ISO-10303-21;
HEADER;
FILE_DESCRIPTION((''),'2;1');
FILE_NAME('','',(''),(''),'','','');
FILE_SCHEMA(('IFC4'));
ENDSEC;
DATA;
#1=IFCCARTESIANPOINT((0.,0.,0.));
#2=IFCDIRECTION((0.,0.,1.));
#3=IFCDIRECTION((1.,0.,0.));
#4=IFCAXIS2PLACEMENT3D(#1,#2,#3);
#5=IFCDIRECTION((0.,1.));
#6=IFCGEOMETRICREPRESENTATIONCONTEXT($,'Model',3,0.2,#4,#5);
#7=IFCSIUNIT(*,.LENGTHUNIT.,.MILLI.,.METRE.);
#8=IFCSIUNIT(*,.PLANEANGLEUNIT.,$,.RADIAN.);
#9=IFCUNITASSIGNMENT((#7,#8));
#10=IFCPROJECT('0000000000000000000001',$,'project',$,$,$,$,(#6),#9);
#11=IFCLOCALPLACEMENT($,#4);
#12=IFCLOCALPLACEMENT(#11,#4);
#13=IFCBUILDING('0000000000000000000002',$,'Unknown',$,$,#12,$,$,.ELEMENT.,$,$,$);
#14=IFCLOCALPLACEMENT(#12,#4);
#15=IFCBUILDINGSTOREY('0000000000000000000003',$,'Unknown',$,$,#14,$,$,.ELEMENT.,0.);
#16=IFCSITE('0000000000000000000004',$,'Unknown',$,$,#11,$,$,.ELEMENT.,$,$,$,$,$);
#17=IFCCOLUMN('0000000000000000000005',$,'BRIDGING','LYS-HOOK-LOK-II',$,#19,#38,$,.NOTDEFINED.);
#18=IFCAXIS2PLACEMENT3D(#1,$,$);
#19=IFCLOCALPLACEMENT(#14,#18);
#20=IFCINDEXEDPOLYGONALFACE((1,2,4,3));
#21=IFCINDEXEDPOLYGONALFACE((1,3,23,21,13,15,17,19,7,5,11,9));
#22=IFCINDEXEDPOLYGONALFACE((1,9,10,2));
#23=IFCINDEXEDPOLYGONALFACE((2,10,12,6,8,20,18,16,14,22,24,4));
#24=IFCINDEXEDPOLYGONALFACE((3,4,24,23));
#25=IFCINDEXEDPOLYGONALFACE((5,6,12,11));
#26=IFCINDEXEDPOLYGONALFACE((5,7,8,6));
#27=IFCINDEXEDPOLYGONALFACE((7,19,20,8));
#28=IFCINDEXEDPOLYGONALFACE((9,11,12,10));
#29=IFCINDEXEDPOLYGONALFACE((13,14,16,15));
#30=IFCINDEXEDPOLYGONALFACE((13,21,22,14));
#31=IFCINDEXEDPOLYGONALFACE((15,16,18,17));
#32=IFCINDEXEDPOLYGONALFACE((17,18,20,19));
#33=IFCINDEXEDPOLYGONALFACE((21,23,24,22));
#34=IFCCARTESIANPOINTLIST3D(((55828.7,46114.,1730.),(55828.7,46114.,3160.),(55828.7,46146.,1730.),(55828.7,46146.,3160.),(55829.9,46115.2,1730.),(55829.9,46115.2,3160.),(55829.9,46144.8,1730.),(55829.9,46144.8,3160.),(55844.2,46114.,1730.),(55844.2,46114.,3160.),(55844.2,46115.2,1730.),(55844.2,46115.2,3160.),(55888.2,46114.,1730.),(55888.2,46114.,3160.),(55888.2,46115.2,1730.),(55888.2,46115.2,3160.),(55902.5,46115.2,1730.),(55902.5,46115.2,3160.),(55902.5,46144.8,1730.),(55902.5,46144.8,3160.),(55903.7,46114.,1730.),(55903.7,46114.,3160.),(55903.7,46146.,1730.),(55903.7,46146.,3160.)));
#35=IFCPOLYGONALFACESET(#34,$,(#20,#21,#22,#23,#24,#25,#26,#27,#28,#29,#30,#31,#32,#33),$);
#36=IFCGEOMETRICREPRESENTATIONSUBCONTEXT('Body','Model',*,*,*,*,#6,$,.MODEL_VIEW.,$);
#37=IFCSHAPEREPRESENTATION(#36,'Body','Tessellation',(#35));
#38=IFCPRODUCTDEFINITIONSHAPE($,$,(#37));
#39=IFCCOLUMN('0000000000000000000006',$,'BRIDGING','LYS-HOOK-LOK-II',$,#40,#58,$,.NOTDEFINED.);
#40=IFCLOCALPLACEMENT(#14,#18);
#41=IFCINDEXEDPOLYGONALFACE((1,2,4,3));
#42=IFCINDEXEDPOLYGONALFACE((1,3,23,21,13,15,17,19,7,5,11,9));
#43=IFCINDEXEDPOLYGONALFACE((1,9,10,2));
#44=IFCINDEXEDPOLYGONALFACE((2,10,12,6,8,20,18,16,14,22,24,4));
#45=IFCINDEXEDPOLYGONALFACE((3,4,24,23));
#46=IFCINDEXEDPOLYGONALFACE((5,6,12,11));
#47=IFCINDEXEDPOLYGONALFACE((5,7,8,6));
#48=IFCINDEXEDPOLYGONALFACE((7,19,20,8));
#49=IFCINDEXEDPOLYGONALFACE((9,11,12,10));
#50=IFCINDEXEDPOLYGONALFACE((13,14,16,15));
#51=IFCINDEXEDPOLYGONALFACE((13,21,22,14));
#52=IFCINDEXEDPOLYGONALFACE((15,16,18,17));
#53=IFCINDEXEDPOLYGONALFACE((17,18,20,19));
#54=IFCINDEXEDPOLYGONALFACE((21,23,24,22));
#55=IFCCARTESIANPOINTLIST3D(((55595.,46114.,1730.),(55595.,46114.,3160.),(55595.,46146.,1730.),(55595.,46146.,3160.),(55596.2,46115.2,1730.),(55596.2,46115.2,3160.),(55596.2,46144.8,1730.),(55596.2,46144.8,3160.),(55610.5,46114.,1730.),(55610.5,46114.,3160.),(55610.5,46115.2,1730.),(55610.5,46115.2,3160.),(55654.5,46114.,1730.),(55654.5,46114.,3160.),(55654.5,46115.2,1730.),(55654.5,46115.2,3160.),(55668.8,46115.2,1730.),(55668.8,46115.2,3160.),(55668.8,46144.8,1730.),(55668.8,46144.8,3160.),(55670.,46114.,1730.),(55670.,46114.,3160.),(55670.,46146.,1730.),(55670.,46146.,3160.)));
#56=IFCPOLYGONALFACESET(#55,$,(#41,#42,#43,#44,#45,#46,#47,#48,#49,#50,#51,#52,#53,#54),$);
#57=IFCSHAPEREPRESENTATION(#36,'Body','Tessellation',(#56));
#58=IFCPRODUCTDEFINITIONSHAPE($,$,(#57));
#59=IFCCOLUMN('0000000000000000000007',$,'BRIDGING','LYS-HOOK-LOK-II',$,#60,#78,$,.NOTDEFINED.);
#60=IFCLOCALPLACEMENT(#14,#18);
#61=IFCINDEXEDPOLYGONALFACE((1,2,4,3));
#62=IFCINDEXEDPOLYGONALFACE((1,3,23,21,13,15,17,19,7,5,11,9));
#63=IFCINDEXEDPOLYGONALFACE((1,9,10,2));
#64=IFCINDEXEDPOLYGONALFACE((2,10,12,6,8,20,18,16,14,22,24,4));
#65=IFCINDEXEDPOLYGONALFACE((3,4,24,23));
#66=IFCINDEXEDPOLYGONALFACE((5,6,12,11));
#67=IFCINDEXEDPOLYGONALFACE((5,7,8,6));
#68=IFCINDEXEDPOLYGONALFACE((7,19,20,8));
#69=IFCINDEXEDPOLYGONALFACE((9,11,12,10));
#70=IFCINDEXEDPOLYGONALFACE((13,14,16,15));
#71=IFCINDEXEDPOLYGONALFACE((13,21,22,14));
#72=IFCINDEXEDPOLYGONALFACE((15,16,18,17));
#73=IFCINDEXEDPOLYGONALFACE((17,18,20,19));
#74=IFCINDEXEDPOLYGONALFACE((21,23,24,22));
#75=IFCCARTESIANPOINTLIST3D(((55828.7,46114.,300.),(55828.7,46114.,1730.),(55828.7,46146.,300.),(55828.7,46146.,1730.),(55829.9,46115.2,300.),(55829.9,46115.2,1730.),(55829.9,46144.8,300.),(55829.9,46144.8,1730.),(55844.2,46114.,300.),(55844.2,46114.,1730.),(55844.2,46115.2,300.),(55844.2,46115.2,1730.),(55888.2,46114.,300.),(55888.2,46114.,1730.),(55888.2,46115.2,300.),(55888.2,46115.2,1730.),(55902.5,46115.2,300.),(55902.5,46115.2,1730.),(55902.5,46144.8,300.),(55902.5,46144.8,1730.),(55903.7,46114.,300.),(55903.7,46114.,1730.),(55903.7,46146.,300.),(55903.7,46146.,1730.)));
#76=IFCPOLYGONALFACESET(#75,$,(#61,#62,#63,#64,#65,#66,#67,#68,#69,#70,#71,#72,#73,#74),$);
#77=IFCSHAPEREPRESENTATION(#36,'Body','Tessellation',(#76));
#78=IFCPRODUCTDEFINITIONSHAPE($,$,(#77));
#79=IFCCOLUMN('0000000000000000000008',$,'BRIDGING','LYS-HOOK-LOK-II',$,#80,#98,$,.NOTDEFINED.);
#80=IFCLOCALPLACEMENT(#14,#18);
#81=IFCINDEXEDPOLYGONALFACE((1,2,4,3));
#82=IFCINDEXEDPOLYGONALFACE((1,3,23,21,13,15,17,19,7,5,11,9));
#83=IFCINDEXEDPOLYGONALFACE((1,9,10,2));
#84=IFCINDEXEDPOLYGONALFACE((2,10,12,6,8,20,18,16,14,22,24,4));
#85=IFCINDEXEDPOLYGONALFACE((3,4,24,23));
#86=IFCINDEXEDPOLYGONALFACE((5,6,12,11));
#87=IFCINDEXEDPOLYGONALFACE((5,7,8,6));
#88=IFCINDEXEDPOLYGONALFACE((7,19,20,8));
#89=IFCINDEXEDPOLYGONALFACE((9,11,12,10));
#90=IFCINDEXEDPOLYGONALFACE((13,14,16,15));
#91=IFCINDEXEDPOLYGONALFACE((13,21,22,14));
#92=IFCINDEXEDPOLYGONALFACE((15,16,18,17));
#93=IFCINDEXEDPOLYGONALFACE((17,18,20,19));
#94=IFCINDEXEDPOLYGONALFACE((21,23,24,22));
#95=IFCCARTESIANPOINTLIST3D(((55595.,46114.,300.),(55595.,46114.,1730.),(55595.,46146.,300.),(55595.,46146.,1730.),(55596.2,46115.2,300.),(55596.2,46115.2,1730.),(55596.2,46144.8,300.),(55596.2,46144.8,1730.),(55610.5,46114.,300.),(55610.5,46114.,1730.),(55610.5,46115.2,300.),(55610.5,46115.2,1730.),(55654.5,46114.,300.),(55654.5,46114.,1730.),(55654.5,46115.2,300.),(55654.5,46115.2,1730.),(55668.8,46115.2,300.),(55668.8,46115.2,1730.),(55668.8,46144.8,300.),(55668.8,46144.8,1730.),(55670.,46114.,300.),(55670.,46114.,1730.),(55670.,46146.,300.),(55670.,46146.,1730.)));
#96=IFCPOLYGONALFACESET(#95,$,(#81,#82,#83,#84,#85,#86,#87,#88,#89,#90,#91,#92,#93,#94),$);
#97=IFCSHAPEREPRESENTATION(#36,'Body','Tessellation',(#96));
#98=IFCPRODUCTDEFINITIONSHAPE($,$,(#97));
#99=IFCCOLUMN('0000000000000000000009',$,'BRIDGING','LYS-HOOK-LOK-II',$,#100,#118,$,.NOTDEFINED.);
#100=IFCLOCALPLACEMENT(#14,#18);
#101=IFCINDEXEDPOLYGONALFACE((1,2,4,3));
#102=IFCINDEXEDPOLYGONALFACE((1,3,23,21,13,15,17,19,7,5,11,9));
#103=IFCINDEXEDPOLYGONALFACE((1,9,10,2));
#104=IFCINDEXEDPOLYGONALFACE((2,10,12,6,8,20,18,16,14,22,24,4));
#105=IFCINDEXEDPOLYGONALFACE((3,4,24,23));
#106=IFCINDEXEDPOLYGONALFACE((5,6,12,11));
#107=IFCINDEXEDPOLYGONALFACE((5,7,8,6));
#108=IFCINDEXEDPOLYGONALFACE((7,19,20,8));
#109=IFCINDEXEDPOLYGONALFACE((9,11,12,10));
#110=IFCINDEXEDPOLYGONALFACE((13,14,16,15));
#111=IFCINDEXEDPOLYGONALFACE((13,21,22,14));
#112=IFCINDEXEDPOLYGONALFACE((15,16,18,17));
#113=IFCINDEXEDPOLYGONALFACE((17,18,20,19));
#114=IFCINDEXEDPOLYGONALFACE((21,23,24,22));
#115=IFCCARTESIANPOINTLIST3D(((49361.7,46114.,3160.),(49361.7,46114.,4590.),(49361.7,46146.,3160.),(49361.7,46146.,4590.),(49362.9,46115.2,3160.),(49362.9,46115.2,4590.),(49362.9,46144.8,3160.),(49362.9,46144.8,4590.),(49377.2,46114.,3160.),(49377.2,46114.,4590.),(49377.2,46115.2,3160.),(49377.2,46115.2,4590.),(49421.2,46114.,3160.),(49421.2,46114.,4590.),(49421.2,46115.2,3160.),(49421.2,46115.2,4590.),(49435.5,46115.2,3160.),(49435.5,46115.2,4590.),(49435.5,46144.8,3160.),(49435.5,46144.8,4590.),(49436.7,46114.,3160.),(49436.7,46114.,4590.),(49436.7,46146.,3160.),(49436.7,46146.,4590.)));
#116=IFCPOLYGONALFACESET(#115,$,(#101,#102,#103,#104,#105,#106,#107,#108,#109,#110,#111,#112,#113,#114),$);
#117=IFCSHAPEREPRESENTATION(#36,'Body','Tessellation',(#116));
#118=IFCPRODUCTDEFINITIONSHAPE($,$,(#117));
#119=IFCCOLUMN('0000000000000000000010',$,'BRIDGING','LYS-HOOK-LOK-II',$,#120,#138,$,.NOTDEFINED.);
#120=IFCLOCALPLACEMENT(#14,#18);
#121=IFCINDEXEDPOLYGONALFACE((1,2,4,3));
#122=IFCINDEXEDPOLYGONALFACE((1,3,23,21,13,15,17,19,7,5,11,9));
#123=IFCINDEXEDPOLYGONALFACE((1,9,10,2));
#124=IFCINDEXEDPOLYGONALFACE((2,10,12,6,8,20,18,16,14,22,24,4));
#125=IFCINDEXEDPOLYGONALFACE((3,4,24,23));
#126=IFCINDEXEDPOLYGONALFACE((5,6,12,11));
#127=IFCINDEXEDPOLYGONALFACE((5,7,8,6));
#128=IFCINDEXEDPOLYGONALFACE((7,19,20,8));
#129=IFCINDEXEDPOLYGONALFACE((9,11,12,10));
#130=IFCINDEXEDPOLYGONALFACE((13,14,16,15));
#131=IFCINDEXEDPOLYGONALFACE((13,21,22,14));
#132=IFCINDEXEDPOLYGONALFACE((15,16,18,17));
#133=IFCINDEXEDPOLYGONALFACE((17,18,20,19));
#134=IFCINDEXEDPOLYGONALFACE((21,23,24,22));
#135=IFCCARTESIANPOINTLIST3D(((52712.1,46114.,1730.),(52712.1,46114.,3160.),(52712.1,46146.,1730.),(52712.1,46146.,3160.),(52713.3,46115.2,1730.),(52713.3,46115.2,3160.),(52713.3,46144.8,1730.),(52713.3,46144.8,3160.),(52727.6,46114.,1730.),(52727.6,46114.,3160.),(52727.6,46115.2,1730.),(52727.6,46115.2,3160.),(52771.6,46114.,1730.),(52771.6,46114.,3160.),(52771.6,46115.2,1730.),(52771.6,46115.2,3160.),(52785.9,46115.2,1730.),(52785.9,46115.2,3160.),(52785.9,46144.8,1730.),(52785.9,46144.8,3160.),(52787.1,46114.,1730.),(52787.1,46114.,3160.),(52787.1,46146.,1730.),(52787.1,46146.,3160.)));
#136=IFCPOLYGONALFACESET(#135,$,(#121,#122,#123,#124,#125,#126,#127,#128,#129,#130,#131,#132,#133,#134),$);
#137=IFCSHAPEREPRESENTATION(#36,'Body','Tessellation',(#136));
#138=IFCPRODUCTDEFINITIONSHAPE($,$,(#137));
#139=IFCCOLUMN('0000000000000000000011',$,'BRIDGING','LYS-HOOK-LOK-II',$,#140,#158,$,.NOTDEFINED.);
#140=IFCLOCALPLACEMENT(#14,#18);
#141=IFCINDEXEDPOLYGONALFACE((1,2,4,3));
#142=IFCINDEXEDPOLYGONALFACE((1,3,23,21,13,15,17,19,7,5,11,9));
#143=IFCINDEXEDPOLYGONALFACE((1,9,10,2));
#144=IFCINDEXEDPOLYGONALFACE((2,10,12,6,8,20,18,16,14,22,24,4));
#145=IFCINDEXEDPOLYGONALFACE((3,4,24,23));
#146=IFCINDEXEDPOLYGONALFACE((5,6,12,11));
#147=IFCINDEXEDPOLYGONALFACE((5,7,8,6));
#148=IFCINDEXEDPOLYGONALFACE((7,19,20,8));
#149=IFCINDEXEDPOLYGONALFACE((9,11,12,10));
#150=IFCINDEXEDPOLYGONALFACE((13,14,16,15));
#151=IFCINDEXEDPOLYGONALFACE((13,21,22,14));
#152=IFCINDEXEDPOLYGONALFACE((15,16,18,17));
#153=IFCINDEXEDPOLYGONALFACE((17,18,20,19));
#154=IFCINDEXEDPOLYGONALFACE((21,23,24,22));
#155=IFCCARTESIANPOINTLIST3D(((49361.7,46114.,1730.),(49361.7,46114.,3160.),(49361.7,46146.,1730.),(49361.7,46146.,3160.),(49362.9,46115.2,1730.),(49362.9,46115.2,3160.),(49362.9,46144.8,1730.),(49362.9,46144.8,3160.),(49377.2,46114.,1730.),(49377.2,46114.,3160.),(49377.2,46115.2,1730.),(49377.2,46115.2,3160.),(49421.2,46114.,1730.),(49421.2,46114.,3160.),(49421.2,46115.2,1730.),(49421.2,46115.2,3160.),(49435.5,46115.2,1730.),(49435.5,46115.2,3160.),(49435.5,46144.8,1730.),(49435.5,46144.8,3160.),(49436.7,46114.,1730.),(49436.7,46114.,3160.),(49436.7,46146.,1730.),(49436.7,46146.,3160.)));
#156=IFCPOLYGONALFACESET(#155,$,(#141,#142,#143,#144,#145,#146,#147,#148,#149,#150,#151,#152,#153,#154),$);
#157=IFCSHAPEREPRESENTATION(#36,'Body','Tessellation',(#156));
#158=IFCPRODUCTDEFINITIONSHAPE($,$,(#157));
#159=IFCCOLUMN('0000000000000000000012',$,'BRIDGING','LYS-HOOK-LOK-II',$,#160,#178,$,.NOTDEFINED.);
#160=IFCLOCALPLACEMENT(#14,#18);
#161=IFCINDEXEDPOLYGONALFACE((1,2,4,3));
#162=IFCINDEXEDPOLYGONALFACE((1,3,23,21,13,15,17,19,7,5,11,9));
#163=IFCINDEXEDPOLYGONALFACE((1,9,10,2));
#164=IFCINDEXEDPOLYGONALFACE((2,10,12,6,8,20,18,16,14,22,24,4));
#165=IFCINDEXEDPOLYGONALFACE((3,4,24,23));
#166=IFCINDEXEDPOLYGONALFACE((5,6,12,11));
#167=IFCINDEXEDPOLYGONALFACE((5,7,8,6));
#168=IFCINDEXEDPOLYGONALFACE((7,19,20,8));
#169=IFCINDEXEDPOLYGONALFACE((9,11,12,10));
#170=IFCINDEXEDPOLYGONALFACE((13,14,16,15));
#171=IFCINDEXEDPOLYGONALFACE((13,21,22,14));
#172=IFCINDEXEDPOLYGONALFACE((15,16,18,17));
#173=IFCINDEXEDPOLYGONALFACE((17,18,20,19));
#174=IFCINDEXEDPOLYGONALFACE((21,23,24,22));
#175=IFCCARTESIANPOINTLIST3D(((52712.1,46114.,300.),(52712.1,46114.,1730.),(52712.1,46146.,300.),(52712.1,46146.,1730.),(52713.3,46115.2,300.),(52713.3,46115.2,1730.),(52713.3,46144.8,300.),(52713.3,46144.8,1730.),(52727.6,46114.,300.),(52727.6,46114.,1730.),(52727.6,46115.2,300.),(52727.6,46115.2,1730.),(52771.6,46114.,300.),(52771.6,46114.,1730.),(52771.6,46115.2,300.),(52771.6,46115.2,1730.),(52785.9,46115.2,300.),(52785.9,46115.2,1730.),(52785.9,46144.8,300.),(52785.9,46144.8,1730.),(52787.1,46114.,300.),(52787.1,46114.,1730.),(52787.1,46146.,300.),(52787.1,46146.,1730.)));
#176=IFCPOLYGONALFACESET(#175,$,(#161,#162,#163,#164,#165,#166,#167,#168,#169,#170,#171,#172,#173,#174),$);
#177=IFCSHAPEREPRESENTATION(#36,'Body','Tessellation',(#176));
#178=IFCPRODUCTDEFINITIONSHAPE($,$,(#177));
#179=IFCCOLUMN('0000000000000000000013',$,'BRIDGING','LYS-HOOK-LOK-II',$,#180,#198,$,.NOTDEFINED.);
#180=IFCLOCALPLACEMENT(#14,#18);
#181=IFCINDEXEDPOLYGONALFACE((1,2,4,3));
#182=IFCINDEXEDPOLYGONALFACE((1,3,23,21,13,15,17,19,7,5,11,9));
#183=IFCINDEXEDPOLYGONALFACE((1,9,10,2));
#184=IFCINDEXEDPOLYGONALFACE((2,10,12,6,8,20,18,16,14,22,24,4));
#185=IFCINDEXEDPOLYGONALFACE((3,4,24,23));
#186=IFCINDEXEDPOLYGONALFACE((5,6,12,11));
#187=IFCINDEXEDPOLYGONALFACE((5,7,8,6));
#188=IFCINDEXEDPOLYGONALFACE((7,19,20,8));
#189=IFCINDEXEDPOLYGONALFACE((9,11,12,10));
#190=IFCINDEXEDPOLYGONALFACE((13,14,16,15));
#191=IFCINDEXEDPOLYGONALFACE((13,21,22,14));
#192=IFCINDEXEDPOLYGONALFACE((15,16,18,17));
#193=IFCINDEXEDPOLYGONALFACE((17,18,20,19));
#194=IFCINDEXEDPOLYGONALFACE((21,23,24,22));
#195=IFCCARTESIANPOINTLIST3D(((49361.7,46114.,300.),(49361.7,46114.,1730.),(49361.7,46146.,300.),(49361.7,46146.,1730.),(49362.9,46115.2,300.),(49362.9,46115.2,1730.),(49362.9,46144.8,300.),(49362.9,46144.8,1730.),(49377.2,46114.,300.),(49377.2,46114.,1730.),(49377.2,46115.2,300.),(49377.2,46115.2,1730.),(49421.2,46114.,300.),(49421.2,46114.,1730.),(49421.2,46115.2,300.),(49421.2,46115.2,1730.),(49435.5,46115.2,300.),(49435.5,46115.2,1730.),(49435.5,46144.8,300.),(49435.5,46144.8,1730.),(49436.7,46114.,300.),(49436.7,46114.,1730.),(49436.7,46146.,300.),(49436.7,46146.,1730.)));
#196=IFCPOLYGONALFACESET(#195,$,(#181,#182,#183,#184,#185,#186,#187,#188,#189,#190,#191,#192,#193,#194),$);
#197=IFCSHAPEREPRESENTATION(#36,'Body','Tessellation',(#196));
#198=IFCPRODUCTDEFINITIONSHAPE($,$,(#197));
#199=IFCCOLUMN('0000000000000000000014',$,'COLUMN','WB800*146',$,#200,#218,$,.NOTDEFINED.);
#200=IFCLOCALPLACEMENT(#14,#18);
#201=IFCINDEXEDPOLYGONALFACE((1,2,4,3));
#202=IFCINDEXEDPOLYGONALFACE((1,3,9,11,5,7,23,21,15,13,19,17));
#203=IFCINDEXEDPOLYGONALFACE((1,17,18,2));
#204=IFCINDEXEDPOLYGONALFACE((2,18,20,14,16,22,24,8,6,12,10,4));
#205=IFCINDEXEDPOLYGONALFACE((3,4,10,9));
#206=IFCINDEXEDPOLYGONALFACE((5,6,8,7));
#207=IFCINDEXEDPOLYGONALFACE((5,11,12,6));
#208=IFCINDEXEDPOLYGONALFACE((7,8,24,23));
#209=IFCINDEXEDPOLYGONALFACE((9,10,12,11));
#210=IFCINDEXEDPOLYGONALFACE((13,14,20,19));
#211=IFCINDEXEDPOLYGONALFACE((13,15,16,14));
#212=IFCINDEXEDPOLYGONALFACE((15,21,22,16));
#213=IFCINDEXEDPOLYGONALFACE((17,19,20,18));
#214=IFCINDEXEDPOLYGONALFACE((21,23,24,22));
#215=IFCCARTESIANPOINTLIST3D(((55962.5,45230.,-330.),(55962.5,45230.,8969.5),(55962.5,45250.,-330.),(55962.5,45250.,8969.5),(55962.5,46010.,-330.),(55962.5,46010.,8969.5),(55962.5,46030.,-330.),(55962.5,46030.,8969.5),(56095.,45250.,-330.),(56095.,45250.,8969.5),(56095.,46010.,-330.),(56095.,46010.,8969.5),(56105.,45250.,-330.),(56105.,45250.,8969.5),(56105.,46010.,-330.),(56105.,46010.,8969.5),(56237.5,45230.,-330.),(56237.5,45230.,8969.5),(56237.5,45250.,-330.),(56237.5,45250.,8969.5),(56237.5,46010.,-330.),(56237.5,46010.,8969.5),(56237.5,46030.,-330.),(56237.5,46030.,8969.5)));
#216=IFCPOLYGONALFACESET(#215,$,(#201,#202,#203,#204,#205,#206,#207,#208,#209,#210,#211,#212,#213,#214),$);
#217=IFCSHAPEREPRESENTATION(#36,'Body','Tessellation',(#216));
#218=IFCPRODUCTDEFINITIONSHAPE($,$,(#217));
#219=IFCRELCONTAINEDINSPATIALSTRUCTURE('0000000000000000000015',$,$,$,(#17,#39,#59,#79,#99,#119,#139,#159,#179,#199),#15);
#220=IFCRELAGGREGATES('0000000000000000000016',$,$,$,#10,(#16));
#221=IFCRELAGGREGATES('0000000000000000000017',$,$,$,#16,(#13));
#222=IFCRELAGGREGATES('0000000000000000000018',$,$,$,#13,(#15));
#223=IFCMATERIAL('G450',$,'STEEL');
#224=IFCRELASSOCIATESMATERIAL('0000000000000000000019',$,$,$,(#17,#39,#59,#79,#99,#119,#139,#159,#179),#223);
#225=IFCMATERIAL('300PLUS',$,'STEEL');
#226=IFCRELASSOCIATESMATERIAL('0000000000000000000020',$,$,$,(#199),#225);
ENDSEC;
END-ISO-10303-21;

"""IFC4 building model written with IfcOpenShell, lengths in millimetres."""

from ifc_helpers import new_model, si_unit, direction, frame, origin_with_axes, place, context, subcontext, project, spatial, line, indexed_curve, outline, extrude, material, element, save


model = new_model("IFC4")

# Units and contexts
model_context = context("Model", 3, precision=0.2, world=origin_with_axes(), true_north=direction((0.0, 1.0)))
body_context = subcontext(model_context, "Body", "Model", "MODEL_VIEW")
ifc_project = project(units=[si_unit("LENGTHUNIT", "METRE", prefix="MILLI"), si_unit("PLANEANGLEUNIT", "RADIAN")], contexts=[model_context])

# Site, building, storey
site_placement = place(None, origin_with_axes())
site = spatial("IfcSite", under=ifc_project, at=site_placement, Name="Unknown", CompositionType="ELEMENT")
building_placement = place(site_placement, origin_with_axes())
building = spatial("IfcBuilding", under=site, at=building_placement, Name="Unknown", CompositionType="ELEMENT")
storey_placement = place(building_placement, origin_with_axes())
storey = spatial("IfcBuildingStorey", under=building, at=storey_placement, Name="Unknown", CompositionType="ELEMENT", Elevation=0.0)

# Columns
ifc_material_1 = material(Name="G450", Category="STEEL")
for number, where, z_axis, x_axis, name in (
    (1, (55866.2, 46130.0, 1730.0), (0.0, -1.0, 0.0), (0.0, 0.0, 1.0), "BRIDGING"),
    (2, (55632.5, 46130.0, 1730.0), (0.0, -1.0, 0.0), (0.0, 0.0, 1.0), "BRIDGING"),
    (3, (55866.2, 46130.0, 300.0), (0.0, -1.0, 0.0), (0.0, 0.0, 1.0), "BRIDGING"),
    (4, (55632.5, 46130.0, 300.0), (0.0, -1.0, 0.0), (0.0, 0.0, 1.0), "BRIDGING"),
    (5, (49399.2, 46130.0, 3160.0), (0.0, -1.0, 0.0), (0.0, 0.0, 1.0), "BRIDGING"),
    (6, (52749.6, 46130.0, 1730.0), (0.0, -1.0, 0.0), (0.0, 0.0, 1.0), "BRIDGING"),
    (7, (49399.2, 46130.0, 1730.0), (0.0, -1.0, 0.0), (0.0, 0.0, 1.0), "BRIDGING"),
    (8, (52749.6, 46130.0, 300.0), (0.0, -1.0, 0.0), (0.0, 0.0, 1.0), "BRIDGING"),
    (9, (49399.2, 46130.0, 300.0), (0.0, -1.0, 0.0), (0.0, 0.0, 1.0), "BRIDGING"),
):
    element("IfcColumn", number, at=place(storey_placement, frame(where, z_axis=z_axis, x_axis=x_axis)), inside=storey, material=ifc_material_1, Name=name, Description="LYS-HOOK-LOK-II", PredefinedType="NOTDEFINED", context=body_context, shape_type="SolidModel", body=[
        extrude(outline(indexed_curve([(16.0, -37.5), (16.0, -22.0), (14.8, -22.0), (14.8, -36.3), (-14.8, -36.3), (-14.8, 36.3), (14.8, 36.3), (14.8, 22.0), (16.0, 22.0), (16.0, 37.5), (-16.0, 37.5), (-16.0, -37.5)], segments=[line(1, 2, 3, 4, 5, 6, 7, 8, 9, 10, 11, 12, 1)])), frame((0.0, 0.0, 0.0), z_axis=(-1.0, 0.0, 0.0), x_axis=(0.0, 0.0, 1.0)), (0.0, 0.0, -1.0), 1430.0),
    ])
ifc_material_2 = material(Name="300PLUS", Category="STEEL")
column_placement = place(storey_placement, frame((56100.0, 45630.0, -330.0), z_axis=(-1.0, 0.0, 0.0), x_axis=(0.0, 0.0, 1.0)))
element("IfcColumn", 10, at=column_placement, inside=storey, material=ifc_material_2, Name="COLUMN", Description="WB800*146", PredefinedType="NOTDEFINED", context=body_context, shape_type="SolidModel", body=[
    extrude(outline(indexed_curve([(-137.5, -400.0), (137.5, -400.0), (137.5, -380.0), (5.0, -380.0), (5.0, 380.0), (137.5, 380.0), (137.5, 400.0), (-137.5, 400.0), (-137.5, 380.0), (-5.0, 380.0), (-5.0, -380.0), (-137.5, -380.0)], segments=[line(1, 2, 3, 4, 5, 6, 7, 8, 9, 10, 11, 12, 1)])), frame((0.0, 0.0, 0.0), z_axis=(-1.0, 0.0, 0.0), x_axis=(0.0, 0.0, 1.0)), (0.0, 0.0, -1.0), 9299.5),
])

save(model, "model.ifc")
